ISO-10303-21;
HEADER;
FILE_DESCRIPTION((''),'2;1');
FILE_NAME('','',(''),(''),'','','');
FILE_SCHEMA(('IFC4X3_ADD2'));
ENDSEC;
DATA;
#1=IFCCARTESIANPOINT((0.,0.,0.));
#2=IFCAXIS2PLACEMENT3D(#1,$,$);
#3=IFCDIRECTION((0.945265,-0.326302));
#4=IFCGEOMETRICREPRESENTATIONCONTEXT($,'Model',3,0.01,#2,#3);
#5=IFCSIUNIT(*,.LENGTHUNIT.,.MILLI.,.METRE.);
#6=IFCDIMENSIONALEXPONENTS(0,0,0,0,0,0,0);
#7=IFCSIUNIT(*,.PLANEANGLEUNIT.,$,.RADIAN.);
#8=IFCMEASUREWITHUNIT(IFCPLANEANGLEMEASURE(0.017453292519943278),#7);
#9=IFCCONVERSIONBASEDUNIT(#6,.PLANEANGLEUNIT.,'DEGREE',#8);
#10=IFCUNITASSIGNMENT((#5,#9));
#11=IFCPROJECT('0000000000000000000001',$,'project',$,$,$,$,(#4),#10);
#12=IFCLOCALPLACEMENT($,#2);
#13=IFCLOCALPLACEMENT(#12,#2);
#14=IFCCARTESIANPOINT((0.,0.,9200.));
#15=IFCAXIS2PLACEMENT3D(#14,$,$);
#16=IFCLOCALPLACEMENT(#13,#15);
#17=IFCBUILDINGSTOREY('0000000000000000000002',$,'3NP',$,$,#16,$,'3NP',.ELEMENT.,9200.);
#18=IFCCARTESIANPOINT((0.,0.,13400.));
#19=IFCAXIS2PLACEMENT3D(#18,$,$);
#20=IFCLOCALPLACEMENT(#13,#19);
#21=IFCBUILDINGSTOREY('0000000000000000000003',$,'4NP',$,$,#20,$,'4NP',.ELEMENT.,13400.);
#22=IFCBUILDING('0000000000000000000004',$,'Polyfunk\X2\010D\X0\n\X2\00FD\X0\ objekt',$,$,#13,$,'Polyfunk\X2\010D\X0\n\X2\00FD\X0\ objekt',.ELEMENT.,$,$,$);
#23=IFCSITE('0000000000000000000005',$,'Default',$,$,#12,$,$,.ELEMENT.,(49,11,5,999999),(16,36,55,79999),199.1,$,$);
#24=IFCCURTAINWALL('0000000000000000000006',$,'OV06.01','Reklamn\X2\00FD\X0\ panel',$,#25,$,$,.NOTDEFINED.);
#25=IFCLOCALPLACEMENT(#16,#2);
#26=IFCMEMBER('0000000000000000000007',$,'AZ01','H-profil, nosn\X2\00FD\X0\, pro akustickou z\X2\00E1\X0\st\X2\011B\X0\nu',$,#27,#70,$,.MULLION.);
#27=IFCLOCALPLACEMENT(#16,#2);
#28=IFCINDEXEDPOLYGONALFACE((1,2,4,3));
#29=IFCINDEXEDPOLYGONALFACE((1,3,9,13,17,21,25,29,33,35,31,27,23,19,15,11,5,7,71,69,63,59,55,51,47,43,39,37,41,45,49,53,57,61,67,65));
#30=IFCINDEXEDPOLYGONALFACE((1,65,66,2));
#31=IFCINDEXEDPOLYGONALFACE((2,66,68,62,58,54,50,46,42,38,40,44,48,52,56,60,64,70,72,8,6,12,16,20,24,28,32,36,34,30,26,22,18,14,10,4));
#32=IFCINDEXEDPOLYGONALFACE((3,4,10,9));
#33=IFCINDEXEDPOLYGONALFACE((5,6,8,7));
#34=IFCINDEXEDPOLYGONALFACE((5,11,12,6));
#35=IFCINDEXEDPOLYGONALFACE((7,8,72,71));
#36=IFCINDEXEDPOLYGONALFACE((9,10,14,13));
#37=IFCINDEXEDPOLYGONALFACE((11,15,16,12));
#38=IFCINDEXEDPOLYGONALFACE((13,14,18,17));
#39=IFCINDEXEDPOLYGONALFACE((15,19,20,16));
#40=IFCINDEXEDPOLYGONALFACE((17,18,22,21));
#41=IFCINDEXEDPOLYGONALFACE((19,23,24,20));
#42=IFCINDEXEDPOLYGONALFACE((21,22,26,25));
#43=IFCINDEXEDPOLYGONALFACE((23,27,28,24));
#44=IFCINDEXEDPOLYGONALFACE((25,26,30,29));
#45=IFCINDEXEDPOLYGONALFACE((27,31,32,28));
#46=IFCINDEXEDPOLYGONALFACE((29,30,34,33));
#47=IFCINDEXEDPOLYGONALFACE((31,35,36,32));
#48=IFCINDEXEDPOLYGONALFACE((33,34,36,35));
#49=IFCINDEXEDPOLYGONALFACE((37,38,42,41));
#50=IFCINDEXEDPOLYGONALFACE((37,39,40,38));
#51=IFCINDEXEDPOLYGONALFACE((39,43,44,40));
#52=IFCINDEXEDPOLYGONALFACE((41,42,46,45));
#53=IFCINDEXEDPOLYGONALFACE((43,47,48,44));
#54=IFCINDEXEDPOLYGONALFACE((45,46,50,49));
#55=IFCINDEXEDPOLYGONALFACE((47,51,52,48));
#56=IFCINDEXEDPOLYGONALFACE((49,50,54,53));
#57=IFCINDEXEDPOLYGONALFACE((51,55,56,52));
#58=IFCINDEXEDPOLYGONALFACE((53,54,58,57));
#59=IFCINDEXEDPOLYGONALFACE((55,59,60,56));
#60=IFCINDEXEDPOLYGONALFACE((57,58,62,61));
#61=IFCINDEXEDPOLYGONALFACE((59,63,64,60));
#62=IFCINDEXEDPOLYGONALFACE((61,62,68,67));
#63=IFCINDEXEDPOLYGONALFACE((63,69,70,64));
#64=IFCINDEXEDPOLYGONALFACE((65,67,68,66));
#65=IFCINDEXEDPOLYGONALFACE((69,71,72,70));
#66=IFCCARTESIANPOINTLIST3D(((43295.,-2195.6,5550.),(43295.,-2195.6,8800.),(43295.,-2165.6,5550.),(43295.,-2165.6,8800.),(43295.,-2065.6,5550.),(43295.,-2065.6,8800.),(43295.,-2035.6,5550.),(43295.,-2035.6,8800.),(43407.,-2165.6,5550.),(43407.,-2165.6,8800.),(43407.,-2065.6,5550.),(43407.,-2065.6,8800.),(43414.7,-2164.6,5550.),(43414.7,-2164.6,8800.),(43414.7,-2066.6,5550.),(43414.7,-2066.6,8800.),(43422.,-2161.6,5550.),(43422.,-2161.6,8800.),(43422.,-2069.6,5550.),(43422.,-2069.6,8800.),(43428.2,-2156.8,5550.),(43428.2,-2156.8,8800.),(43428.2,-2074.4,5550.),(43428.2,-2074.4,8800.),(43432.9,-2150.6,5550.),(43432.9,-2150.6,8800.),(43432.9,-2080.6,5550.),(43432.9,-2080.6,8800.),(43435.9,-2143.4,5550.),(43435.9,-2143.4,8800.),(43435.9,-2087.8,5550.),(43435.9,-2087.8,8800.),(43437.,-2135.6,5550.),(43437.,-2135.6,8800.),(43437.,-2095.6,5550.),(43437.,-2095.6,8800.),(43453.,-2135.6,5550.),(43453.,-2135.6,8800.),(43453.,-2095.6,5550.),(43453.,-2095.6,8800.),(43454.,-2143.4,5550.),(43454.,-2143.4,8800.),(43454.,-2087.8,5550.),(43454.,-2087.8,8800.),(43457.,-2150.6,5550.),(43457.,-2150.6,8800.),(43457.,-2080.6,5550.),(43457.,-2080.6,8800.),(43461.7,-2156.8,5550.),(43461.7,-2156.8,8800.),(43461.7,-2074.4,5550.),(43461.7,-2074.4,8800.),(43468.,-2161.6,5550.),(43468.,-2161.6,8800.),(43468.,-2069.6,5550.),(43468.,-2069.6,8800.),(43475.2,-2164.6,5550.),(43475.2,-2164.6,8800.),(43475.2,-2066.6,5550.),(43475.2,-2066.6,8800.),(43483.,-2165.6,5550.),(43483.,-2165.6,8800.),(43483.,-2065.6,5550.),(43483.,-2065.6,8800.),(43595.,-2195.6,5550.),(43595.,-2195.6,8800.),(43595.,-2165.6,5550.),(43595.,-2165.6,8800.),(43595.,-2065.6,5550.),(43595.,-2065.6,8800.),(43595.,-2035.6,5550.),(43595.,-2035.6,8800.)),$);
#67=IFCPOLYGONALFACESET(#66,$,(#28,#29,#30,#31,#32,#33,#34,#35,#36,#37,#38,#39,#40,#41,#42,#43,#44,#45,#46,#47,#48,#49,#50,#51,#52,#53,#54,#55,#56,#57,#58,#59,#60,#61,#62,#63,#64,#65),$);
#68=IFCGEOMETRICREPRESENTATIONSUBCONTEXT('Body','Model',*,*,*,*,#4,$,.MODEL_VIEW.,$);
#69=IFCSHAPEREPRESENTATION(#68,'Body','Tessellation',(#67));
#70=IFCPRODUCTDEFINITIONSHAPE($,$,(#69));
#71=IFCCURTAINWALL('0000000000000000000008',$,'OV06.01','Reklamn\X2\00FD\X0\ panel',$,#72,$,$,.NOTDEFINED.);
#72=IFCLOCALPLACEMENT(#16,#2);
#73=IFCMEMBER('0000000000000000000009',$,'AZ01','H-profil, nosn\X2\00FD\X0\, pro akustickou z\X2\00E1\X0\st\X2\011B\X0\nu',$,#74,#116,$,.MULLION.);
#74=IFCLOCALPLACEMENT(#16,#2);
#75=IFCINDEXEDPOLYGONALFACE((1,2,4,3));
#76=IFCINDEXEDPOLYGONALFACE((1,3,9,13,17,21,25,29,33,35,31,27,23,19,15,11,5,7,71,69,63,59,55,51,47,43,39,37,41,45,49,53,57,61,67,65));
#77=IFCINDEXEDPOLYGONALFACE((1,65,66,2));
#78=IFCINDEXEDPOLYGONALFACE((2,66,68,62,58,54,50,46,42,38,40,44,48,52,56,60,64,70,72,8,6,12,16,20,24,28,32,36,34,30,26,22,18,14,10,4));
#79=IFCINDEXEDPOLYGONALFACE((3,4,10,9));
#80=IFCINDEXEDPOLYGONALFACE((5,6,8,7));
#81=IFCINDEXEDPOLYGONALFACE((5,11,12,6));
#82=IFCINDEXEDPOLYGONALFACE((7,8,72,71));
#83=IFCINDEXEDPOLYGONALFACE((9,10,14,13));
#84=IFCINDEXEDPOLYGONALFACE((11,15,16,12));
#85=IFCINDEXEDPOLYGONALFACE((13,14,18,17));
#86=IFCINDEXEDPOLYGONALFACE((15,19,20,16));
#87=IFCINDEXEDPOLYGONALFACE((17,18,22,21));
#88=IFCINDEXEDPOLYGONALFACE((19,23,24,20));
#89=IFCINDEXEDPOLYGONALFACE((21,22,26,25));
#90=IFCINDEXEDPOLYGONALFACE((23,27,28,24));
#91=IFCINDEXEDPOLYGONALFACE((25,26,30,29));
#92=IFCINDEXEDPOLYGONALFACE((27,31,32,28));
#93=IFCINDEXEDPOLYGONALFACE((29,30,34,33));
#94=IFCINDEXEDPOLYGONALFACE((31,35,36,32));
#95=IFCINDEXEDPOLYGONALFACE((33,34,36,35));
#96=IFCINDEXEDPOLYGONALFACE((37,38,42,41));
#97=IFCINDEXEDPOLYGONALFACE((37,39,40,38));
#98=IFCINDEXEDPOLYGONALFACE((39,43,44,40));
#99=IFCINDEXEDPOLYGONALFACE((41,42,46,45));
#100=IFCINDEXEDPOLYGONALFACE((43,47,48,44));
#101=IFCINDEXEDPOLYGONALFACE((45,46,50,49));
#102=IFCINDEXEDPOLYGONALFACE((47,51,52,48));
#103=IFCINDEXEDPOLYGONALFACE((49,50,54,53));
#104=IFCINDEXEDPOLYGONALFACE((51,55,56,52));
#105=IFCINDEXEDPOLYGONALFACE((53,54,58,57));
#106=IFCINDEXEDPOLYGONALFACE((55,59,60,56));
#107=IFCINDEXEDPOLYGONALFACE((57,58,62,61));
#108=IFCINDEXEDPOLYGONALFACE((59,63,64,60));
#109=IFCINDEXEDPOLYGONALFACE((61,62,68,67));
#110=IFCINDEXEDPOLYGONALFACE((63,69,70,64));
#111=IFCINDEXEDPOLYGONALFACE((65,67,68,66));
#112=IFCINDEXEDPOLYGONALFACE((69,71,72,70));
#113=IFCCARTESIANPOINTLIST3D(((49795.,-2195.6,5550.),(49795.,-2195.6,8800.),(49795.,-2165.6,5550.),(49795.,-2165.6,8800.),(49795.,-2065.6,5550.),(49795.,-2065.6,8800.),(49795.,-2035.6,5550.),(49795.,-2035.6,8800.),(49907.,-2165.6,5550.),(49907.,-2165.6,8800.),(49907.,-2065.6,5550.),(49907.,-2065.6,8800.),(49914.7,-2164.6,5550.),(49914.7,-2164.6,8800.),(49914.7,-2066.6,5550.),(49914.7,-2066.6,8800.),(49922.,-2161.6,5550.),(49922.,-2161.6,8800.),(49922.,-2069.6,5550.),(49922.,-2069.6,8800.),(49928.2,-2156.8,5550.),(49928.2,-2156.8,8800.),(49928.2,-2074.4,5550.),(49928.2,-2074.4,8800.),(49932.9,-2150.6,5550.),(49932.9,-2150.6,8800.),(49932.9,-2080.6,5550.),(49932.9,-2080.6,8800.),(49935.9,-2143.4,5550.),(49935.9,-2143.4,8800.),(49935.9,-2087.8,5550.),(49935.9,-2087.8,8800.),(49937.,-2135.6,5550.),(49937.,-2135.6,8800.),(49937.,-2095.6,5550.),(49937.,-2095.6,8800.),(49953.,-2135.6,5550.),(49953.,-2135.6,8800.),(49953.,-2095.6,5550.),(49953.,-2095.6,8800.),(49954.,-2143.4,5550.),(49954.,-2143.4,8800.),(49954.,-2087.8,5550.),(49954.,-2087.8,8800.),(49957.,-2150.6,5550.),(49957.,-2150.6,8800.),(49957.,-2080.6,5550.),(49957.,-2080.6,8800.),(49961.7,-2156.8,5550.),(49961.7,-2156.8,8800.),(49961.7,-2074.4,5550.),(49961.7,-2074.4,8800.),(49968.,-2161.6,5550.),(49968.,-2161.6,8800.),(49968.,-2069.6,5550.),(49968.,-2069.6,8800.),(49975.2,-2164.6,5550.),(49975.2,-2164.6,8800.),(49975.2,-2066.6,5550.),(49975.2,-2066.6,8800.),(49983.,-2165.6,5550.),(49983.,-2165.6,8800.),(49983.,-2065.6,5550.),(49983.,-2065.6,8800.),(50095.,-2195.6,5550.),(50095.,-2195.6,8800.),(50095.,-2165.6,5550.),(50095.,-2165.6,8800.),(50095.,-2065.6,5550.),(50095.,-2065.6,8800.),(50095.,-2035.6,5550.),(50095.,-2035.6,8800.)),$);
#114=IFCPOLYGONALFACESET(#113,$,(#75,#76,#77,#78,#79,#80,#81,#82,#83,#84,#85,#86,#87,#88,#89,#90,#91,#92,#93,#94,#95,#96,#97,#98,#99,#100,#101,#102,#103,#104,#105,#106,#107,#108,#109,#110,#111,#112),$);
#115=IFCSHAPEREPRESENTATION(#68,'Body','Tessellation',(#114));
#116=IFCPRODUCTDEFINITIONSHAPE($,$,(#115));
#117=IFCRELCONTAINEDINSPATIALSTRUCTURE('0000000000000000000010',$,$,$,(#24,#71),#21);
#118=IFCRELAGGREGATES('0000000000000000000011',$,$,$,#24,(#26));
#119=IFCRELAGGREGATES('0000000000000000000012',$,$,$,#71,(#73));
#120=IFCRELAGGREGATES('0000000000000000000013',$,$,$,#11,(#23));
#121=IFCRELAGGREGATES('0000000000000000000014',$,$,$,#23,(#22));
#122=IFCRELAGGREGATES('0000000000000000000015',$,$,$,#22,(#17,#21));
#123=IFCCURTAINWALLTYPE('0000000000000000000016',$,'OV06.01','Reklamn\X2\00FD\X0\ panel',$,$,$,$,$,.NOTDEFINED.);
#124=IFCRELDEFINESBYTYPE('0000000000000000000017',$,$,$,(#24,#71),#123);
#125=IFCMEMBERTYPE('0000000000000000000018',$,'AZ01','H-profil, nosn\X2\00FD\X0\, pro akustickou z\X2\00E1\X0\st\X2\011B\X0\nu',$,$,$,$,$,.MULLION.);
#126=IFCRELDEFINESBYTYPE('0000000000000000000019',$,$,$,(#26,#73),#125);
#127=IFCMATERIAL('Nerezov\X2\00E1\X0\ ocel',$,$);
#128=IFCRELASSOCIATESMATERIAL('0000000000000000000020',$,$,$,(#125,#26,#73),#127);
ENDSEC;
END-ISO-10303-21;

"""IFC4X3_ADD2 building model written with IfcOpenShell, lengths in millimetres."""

from ifc_helpers import new_model, entity, si_unit, converted_unit, direction, frame, frame_2d, origin, place, context, subcontext, project, spatial, polyline, circle_curve, parameter, trimmed, segment, composite_curve, outline, extrude, source, transform, mapped, material, material_profile, profile_set, profile_usage, type_object, element, aggregate, save


model = new_model("IFC4X3_ADD2")

# Units and contexts
model_context = context("Model", 3, precision=0.01, world=origin(), true_north=direction((0.945265, -0.326302)))
body_context = subcontext(model_context, "Body", "Model", "MODEL_VIEW")
ifc_project = project(units=[si_unit("LENGTHUNIT", "METRE", prefix="MILLI"), converted_unit("PLANEANGLEUNIT", "DEGREE", entity("IfcPlaneAngleMeasure", 0.017453292519943278), si_unit("PLANEANGLEUNIT", "RADIAN"), dimensions=[0, 0, 0, 0, 0, 0, 0])], contexts=[model_context])

# Site, building, storey
site_placement = place(None, origin())
site = spatial("IfcSite", under=ifc_project, at=site_placement, Name="Default", CompositionType="ELEMENT", RefLatitude=(49, 11, 5, 999999), RefLongitude=(16, 36, 55, 79999), RefElevation=199.1)
building_placement = place(site_placement, origin())
building = spatial("IfcBuilding", under=site, at=building_placement, Name="Polyfunkčný objekt", LongName="Polyfunkčný objekt", CompositionType="ELEMENT")
storey_1_placement = place(building_placement, frame((0.0, 0.0, 9200.0)))
storey_1 = spatial("IfcBuildingStorey", under=building, at=storey_1_placement, Name="3NP", LongName="3NP", CompositionType="ELEMENT", Elevation=9200.0)

# Shared definitions
storey_2_placement = place(building_placement, frame((0.0, 0.0, 13400.0)))
storey_2 = spatial("IfcBuildingStorey", under=building, at=storey_2_placement, Name="4NP", LongName="4NP", CompositionType="ELEMENT", Elevation=13400.0)

# Shared definitions
ifc_material_1 = material(Name="Nerezová ocel")
ifc_material_profile_1 = material_profile(ifc_material_1, outline(composite_curve([segment(polyline([(50.0, -150.0), (80.0, -150.0)]), True, "CONTINUOUS"), segment(polyline([(80.0, -150.0), (80.0, 150.0)]), True, "CONTINUOUS"), segment(polyline([(80.0, 150.0), (50.0, 150.0)]), True, "CONTINUOUS"), segment(polyline([(50.0, 150.0), (50.0, 38.0)]), True, "CONTINUOUS"), segment(trimmed(circle_curve(frame_2d((20.0, 38.0), x_axis=(0.0, 1.0)), 30.0), [parameter(180.0)], [parameter(270.0)], True, "PARAMETER"), False, "CONTINUOUS"), segment(polyline([(20.0, 8.0), (-20.0, 8.0)]), True, "CONTINUOUS"), segment(trimmed(circle_curve(frame_2d((-20.0, 38.0), x_axis=(0.0, 1.0)), 30.0), [parameter(90.0)], [parameter(180.0)], True, "PARAMETER"), False, "CONTINUOUS"), segment(polyline([(-50.0, 38.0), (-50.0, 150.0)]), True, "CONTINUOUS"), segment(polyline([(-50.0, 150.0), (-80.0, 150.0)]), True, "CONTINUOUS"), segment(polyline([(-80.0, 150.0), (-80.0, -150.0)]), True, "CONTINUOUS"), segment(polyline([(-80.0, -150.0), (-50.0, -150.0)]), True, "CONTINUOUS"), segment(polyline([(-50.0, -150.0), (-50.0, -38.0)]), True, "CONTINUOUS"), segment(trimmed(circle_curve(frame_2d((-20.0, -38.0), x_axis=(0.0, 1.0)), 30.0), [parameter(0.0)], [parameter(90.0)], True, "PARAMETER"), False, "CONTINUOUS"), segment(polyline([(-20.0, -8.0), (20.0, -8.0)]), True, "CONTINUOUS"), segment(trimmed(circle_curve(frame_2d((20.0, -38.0), x_axis=(0.0, 1.0)), 30.0), [parameter(270.0)], [parameter(0.0)], True, "PARAMETER"), False, "CONTINUOUS"), segment(polyline([(50.0, -38.0), (50.0, -150.0)]), True, "CONTINUOUS")], self_intersect=False)), Name="Profil zástena")
ifc_profile_set_1 = profile_set([ifc_material_profile_1], Name="Profil zástena")
ifc_profile_usage_1 = profile_usage(ifc_profile_set_1)
member_type_1 = type_object("IfcMemberType", Name="AZ01", Description="H-profil, nosný, pro akustickou zástěnu", PredefinedType="MULLION", material=ifc_profile_set_1)

# Curtain walls, members
curtain_wall_type_1 = type_object("IfcCurtainWallType", Name="OV06.01", Description="Reklamný panel", PredefinedType="NOTDEFINED")
curtain_wall_1_placement = place(storey_2_placement, frame((0.0, 0.0, -13400.0)))
curtain_wall_1 = element("IfcCurtainWall", 1, at=curtain_wall_1_placement, inside=storey_2, type_object=curtain_wall_type_1, Name="OV06.01", Description="Reklamný panel", PredefinedType="NOTDEFINED")
shared_shape_1 = source(origin(), body_context, "Body", "SweptSolid", [
    extrude(outline(composite_curve([segment(polyline([(50.0, -150.0), (80.0, -150.0)]), True, "CONTINUOUS"), segment(polyline([(80.0, -150.0), (80.0, 150.0)]), True, "CONTINUOUS"), segment(polyline([(80.0, 150.0), (50.0, 150.0)]), True, "CONTINUOUS"), segment(polyline([(50.0, 150.0), (50.0, 38.0)]), True, "CONTINUOUS"), segment(trimmed(circle_curve(frame_2d((20.0, 38.0), x_axis=(0.0, 1.0)), 30.0), [parameter(180.0)], [parameter(270.0)], True, "PARAMETER"), False, "CONTINUOUS"), segment(polyline([(20.0, 8.0), (-20.0, 8.0)]), True, "CONTINUOUS"), segment(trimmed(circle_curve(frame_2d((-20.0, 38.0), x_axis=(0.0, 1.0)), 30.0), [parameter(90.0)], [parameter(180.0)], True, "PARAMETER"), False, "CONTINUOUS"), segment(polyline([(-50.0, 38.0), (-50.0, 150.0)]), True, "CONTINUOUS"), segment(polyline([(-50.0, 150.0), (-80.0, 150.0)]), True, "CONTINUOUS"), segment(polyline([(-80.0, 150.0), (-80.0, -150.0)]), True, "CONTINUOUS"), segment(polyline([(-80.0, -150.0), (-50.0, -150.0)]), True, "CONTINUOUS"), segment(polyline([(-50.0, -150.0), (-50.0, -38.0)]), True, "CONTINUOUS"), segment(trimmed(circle_curve(frame_2d((-20.0, -38.0), x_axis=(0.0, 1.0)), 30.0), [parameter(0.0)], [parameter(90.0)], True, "PARAMETER"), False, "CONTINUOUS"), segment(polyline([(-20.0, -8.0), (20.0, -8.0)]), True, "CONTINUOUS"), segment(trimmed(circle_curve(frame_2d((20.0, -38.0), x_axis=(0.0, 1.0)), 30.0), [parameter(270.0)], [parameter(0.0)], True, "PARAMETER"), False, "CONTINUOUS"), segment(polyline([(50.0, -38.0), (50.0, -150.0)]), True, "CONTINUOUS")], self_intersect=False)), frame((-150.0, 0.0, -3250.0), z_axis=(0.0, 0.0, 1.0), x_axis=(0.0, 1.0, 0.0)), (0.0, 0.0, 1.0), 3250.0),
])
member_1_placement = place(curtain_wall_1_placement, frame((43295.0, -2115.6, 18000.0), z_axis=(0.0, 0.0, 1.0), x_axis=(-1.0, 0.0, 0.0)))
member_1 = element("IfcMember", 2, at=member_1_placement, type_object=member_type_1, material=ifc_profile_usage_1, Name="AZ01", Description="H-profil, nosný, pro akustickou zástěnu", PredefinedType="MULLION", context=body_context, shape_type="MappedRepresentation", body=[
    mapped(shared_shape_1, transform((0.0, 0.0, 0.0), scale=1.0)),
])
curtain_wall_2_placement = place(storey_2_placement, frame((0.0, 0.0, -13400.0)))
curtain_wall_2 = element("IfcCurtainWall", 3, at=curtain_wall_2_placement, inside=storey_2, type_object=curtain_wall_type_1, Name="OV06.01", Description="Reklamný panel", PredefinedType="NOTDEFINED")
member_2_placement = place(curtain_wall_2_placement, frame((49795.0, -2115.6, 18000.0), z_axis=(0.0, 0.0, 1.0), x_axis=(-1.0, 0.0, 0.0)))
member_2 = element("IfcMember", 4, at=member_2_placement, type_object=member_type_1, material=ifc_profile_usage_1, Name="AZ01", Description="H-profil, nosný, pro akustickou zástěnu", PredefinedType="MULLION", context=body_context, shape_type="MappedRepresentation", body=[
    mapped(shared_shape_1, transform((0.0, 0.0, 0.0), scale=1.0)),
])

aggregate(curtain_wall_1, [member_1])
aggregate(curtain_wall_2, [member_2])

save(model, "model.ifc")
